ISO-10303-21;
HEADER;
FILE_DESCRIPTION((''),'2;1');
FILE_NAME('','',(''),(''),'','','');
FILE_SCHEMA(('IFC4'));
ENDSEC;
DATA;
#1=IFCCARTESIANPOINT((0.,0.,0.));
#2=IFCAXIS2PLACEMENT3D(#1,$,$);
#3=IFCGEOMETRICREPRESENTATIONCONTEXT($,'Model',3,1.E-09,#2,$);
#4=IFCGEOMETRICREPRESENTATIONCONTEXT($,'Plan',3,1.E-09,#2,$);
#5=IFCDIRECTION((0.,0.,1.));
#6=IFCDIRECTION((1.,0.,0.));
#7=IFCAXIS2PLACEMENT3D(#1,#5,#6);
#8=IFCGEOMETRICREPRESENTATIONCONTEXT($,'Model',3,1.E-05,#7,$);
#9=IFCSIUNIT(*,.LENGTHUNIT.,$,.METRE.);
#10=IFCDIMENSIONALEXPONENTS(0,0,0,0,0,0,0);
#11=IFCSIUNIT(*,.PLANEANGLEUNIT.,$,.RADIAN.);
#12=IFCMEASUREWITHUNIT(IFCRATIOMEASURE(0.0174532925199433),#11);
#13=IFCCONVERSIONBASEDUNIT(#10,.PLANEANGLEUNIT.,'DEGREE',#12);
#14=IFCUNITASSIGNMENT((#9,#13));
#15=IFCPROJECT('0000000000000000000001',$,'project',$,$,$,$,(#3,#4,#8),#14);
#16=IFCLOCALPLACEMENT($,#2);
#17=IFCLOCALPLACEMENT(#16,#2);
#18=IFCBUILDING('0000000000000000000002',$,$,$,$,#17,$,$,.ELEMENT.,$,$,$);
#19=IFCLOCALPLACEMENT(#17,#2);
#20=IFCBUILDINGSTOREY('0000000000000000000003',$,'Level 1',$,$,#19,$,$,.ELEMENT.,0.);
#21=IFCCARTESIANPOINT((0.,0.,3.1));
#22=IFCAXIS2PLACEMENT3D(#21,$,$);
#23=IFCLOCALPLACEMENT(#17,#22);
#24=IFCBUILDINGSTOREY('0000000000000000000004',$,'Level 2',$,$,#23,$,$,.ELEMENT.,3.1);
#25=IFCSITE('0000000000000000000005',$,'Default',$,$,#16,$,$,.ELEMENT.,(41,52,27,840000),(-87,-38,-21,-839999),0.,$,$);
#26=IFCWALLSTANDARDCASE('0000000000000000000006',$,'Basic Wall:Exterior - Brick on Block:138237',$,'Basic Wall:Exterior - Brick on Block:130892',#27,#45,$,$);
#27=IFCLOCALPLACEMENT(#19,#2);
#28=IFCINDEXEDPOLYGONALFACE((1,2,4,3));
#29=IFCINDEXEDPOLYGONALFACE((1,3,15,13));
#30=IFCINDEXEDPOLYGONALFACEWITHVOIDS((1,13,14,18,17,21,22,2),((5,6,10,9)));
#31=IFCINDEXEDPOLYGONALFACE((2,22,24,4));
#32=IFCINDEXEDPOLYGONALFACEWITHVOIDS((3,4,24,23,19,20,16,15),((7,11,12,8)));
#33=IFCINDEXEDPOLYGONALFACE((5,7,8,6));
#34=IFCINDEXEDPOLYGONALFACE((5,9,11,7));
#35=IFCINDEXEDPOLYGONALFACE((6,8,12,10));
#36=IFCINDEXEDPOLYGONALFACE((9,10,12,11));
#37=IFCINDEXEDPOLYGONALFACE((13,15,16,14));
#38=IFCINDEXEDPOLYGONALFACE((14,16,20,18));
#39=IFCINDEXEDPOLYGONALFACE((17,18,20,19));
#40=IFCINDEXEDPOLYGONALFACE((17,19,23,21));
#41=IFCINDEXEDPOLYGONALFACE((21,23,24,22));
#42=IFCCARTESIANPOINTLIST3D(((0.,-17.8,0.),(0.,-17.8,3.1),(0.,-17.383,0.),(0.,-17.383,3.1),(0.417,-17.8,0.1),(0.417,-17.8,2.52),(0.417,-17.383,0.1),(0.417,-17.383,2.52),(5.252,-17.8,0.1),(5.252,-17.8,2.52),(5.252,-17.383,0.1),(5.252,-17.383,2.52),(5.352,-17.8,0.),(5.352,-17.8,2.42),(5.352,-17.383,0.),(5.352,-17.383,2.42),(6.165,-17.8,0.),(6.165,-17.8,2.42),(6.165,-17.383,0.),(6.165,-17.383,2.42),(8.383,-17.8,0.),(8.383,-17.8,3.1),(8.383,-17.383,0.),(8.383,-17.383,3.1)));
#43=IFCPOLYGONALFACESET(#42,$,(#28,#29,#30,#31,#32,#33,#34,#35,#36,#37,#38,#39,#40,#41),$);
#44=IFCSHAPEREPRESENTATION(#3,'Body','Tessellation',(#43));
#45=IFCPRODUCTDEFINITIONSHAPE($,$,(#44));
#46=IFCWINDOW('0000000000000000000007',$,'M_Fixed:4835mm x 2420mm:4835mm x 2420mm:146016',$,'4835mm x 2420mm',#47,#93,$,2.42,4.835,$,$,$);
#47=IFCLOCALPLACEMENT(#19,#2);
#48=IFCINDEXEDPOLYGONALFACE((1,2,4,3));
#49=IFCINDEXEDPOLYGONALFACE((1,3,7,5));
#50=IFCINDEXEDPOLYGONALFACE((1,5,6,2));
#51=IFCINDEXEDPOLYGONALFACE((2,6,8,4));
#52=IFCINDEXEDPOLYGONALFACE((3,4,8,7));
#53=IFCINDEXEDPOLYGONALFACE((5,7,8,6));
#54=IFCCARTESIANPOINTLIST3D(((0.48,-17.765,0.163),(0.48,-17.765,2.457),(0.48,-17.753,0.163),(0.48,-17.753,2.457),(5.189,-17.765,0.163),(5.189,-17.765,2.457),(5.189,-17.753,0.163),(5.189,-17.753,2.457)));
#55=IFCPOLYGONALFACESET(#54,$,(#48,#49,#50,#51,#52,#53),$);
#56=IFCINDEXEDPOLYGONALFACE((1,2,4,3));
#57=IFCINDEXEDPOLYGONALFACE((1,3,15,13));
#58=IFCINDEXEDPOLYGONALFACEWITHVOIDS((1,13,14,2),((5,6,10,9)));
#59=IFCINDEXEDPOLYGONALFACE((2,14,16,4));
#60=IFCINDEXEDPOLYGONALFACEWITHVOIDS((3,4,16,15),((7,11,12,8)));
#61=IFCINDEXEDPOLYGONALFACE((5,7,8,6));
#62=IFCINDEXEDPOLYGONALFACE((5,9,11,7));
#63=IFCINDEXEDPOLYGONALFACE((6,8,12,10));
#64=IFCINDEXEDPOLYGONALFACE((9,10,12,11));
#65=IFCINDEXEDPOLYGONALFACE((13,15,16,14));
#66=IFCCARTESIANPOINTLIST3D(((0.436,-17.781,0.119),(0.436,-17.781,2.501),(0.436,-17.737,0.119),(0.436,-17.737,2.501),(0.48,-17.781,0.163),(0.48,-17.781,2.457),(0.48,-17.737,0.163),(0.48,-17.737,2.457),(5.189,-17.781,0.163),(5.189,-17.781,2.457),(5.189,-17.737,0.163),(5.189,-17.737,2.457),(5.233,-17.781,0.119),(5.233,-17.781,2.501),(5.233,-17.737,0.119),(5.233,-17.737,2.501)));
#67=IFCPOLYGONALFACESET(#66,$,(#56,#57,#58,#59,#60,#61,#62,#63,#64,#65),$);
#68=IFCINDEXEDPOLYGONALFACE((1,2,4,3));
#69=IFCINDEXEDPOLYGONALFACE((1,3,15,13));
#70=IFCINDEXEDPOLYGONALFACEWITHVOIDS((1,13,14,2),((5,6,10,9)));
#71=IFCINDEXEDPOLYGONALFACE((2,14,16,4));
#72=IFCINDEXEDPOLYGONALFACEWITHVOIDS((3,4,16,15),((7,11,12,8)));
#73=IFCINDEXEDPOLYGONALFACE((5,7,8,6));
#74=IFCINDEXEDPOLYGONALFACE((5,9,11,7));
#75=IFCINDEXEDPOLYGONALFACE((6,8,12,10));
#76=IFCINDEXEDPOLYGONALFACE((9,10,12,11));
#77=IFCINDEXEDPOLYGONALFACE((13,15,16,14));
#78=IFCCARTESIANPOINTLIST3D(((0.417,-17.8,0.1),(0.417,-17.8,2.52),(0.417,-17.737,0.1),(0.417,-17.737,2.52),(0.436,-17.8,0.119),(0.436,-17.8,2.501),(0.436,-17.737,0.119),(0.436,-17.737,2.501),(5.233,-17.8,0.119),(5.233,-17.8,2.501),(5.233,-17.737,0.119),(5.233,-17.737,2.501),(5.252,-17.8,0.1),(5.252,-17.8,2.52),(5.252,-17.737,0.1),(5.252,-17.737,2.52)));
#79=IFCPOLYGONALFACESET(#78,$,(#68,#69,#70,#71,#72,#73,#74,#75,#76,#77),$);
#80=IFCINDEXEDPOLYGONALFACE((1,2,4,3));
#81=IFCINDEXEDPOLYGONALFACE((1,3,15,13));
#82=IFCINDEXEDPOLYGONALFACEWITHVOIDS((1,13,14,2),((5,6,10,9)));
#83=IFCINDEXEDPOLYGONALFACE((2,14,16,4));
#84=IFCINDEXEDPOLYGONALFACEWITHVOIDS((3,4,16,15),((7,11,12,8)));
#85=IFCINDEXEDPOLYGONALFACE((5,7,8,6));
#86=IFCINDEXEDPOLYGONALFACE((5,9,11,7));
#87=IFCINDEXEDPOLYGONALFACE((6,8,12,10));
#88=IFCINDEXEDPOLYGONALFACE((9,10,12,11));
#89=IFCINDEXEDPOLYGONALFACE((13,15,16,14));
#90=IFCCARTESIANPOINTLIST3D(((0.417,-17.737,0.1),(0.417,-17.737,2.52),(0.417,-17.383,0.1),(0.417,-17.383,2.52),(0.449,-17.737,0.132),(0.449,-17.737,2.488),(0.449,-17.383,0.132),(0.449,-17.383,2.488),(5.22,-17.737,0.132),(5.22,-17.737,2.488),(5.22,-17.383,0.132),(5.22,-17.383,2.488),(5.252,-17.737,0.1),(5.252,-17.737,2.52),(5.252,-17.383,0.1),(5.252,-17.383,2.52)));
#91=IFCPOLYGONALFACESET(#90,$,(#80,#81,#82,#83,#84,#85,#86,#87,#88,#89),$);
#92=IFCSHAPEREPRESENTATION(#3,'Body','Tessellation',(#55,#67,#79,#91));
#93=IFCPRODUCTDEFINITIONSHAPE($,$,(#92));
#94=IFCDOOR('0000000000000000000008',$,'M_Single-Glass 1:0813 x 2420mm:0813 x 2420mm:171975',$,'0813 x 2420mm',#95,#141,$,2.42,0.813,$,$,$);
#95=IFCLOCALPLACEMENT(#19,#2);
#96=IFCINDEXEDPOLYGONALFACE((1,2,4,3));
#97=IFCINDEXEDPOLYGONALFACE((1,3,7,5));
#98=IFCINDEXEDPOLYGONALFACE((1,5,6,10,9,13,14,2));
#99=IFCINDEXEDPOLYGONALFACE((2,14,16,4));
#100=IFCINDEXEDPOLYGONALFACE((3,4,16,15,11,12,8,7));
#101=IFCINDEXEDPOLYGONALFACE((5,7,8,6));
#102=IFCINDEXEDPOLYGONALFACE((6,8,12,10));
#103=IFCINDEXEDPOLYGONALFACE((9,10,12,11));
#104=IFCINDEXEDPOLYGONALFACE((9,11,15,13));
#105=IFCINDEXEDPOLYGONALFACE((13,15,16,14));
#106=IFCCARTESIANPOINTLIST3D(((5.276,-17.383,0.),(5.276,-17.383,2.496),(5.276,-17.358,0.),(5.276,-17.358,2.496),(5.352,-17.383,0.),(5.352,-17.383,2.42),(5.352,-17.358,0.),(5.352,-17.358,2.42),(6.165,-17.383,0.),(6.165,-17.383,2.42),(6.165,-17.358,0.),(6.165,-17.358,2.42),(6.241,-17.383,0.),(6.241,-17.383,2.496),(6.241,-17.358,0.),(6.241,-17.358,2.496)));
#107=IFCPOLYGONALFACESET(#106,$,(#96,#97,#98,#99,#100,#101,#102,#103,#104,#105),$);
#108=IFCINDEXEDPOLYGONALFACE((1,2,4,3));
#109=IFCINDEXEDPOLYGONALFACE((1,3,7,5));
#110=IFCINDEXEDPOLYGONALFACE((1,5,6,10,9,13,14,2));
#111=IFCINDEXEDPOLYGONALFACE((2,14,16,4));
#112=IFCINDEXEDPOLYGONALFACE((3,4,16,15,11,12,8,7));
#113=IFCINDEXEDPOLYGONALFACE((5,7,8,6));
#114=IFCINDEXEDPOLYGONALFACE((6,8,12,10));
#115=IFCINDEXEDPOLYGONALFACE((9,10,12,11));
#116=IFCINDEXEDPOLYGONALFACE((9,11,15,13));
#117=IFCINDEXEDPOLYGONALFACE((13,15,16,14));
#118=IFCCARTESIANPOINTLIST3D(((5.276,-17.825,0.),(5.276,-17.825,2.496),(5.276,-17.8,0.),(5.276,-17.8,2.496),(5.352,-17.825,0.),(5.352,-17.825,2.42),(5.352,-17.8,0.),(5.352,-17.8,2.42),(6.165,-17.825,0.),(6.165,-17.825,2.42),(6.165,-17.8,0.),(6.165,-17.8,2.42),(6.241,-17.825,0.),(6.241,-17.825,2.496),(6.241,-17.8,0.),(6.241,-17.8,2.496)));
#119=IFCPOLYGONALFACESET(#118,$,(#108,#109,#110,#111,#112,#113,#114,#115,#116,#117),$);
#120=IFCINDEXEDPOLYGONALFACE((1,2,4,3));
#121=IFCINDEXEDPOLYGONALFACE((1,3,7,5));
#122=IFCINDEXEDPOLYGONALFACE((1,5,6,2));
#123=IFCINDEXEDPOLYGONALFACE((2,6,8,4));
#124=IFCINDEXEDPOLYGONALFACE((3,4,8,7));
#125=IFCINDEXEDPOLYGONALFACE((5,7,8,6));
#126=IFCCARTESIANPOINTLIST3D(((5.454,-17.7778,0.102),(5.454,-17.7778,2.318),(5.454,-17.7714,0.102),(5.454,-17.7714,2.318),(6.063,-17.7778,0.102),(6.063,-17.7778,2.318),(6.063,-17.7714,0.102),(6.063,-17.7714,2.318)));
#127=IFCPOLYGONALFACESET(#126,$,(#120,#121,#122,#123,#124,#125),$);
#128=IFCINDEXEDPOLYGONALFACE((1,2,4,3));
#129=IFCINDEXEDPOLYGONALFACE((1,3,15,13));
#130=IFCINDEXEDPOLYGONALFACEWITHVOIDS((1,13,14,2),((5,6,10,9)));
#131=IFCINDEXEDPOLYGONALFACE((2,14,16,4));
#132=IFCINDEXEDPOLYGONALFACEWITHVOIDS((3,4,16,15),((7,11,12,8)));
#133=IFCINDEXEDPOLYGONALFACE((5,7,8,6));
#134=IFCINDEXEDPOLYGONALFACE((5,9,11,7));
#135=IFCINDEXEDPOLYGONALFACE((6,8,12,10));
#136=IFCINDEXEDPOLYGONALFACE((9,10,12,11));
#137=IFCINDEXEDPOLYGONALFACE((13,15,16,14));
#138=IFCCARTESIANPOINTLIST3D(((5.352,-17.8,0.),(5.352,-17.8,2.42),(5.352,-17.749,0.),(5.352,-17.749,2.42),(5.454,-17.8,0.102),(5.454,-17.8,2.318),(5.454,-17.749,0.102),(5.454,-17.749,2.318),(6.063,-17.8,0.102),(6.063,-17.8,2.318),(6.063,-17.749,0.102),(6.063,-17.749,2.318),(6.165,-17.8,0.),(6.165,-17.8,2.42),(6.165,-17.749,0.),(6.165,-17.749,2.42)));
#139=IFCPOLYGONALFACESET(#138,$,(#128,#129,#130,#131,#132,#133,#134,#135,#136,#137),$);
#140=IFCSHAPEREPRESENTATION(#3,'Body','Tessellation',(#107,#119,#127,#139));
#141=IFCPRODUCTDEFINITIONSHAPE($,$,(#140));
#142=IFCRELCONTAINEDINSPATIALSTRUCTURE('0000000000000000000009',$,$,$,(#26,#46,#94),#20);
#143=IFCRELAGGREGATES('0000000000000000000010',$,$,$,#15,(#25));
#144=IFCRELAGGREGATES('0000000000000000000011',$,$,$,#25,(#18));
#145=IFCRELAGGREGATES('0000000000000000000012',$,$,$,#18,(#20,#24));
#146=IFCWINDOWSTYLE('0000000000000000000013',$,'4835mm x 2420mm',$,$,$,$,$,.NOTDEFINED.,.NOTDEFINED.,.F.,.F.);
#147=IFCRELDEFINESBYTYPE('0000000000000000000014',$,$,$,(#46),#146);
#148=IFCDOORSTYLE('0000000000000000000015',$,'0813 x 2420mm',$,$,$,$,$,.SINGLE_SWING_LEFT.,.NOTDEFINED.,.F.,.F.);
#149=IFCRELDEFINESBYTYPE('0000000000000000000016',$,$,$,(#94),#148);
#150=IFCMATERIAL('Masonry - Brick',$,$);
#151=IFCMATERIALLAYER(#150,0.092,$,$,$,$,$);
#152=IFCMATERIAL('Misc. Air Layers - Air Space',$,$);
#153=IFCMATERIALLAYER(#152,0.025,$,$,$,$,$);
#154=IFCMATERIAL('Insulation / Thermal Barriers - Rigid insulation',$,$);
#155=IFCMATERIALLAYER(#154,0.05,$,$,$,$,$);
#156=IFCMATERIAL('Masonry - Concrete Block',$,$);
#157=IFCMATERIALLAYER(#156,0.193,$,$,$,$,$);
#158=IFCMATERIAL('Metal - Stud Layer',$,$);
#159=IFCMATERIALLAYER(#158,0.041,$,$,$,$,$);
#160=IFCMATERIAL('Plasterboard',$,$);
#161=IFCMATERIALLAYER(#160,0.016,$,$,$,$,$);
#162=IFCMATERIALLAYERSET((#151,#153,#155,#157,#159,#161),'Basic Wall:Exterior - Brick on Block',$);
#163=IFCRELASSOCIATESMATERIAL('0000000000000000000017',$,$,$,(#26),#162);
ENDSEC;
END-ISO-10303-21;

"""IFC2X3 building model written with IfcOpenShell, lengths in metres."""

from ifc_helpers import new_model, entity, si_unit, converted_unit, frame, frame_2d, origin, origin_with_axes, origin_2d_with_axis, place, context, project, spatial, polyline, rectangle, outline, extrude, source, transform, mapped, material, layer, layer_set, layer_usage, type_object, type_shapes, element, fill, save


model = new_model("IFC2X3")

# Units and contexts
model_context_1 = context("Model", 3, precision=1e-09, world=origin())
plan_context = context("Plan", 3, precision=1e-09, world=origin())
model_context_2 = context("Model", 3, precision=1e-05, world=origin_with_axes())
ifc_project = project(units=[si_unit("LENGTHUNIT", "METRE"), converted_unit("PLANEANGLEUNIT", "DEGREE", entity("IfcRatioMeasure", 0.0174532925199433), si_unit("PLANEANGLEUNIT", "RADIAN"), dimensions=[0, 0, 0, 0, 0, 0, 0])], contexts=[model_context_1, plan_context, model_context_2])

# Site, building, storey
site_placement = place(None, origin())
site = spatial("IfcSite", under=ifc_project, at=site_placement, Name="Default", CompositionType="ELEMENT", RefLatitude=(41, 52, 27, 840000), RefLongitude=(-87, -38, -21, -839999), RefElevation=0.0)
building_placement = place(site_placement, origin())
building = spatial("IfcBuilding", under=site, at=building_placement, CompositionType="ELEMENT")
storey_1_placement = place(building_placement, origin())
storey_1 = spatial("IfcBuildingStorey", under=building, at=storey_1_placement, Name="Level 1", CompositionType="ELEMENT", Elevation=0.0)

# Wall, openings, window, door
ifc_material_1 = material(Name="Masonry - Brick")
ifc_layer_1 = layer(ifc_material_1, 0.092)
ifc_material_2 = material(Name="Misc. Air Layers - Air Space")
ifc_layer_2 = layer(ifc_material_2, 0.025)
ifc_material_3 = material(Name="Insulation / Thermal Barriers - Rigid insulation")
ifc_layer_3 = layer(ifc_material_3, 0.05)
ifc_material_4 = material(Name="Masonry - Concrete Block")
ifc_layer_4 = layer(ifc_material_4, 0.193)
ifc_material_5 = material(Name="Metal - Stud Layer")
ifc_layer_5 = layer(ifc_material_5, 0.041)
ifc_material_6 = material(Name="Plasterboard")
ifc_layer_6 = layer(ifc_material_6, 0.016)
ifc_layer_set_1 = layer_set([ifc_layer_1, ifc_layer_2, ifc_layer_3, ifc_layer_4, ifc_layer_5, ifc_layer_6], Name="Basic Wall:Exterior - Brick on Block")
ifc_layer_usage_1 = layer_usage(ifc_layer_set_1, "AXIS2", "NEGATIVE", 0.2085)
wall_1_placement = place(storey_1_placement, frame((8.383, -17.5915, 0.0), z_axis=(0.0, 0.0, 1.0), x_axis=(-1.0, 0.0, 0.0)))
wall_1 = element("IfcWallStandardCase", 1, at=wall_1_placement, inside=storey_1, material=ifc_layer_usage_1, Name="Basic Wall:Exterior - Brick on Block:138237", ObjectType="Basic Wall:Exterior - Brick on Block:130892", context=model_context_1, shape_type="SweptSolid", body=[
    extrude(rectangle(XDim=8.383, YDim=0.417, at=frame_2d((4.1915, 0.0), x_axis=(-1.0, 0.0))), origin(), (0.0, 0.0, 1.0), 3.1),
])
opening_1_placement = place(wall_1_placement, frame((3.131, -0.2085, 0.1)))
opening_1 = element("IfcOpeningElement", 2, at=opening_1_placement, cuts=wall_1, ObjectType="Opening", context=model_context_1, shape_type="SweptSolid", body=[
    extrude(rectangle(XDim=2.42, YDim=4.835, at=frame_2d((1.21, 2.4175), x_axis=(1.0, 0.0))), frame((0.0, 0.0, 0.0), z_axis=(0.0, 1.0, 0.0), x_axis=(0.0, 0.0, 1.0)), (0.0, 0.0, 1.0), 0.417),
])
opening_2_placement = place(wall_1_placement, frame((2.218, -0.2085, 0.0)))
opening_2 = element("IfcOpeningElement", 3, at=opening_2_placement, cuts=wall_1, ObjectType="Opening", context=model_context_1, shape_type="SweptSolid", body=[
    extrude(rectangle(XDim=0.813, YDim=2.42, at=frame_2d((1.21, 0.4065), x_axis=(0.0, -1.0))), frame((0.0, 0.0, 0.0), z_axis=(0.0, 1.0, 0.0), x_axis=(0.0, 0.0, 1.0)), (0.0, 0.0, 1.0), 0.417),
])
window_style_1 = type_object("IfcWindowStyle", Name="4835mm x 2420mm", ConstructionType="NOTDEFINED", OperationType="NOTDEFINED", ParameterTakesPrecedence=False, Sizeable=False)
shared_shape_1 = source(origin(), model_context_1, "Body", "SweptSolid", [
    extrude(rectangle(XDim=0.012, YDim=4.709, at=origin_2d_with_axis()), frame((2.4175, 0.376, 0.063), z_axis=(0.0, 0.0, 1.0), x_axis=(0.0, -1.0, 0.0)), (0.0, 0.0, 1.0), 2.294),
    extrude(outline(polyline([(-2.3985, -1.191), (2.3985, -1.191), (2.3985, 1.191), (-2.3985, 1.191), (-2.3985, -1.191)]), holes=[polyline([(-2.3545, -1.147), (-2.3545, 1.147), (2.3545, 1.147), (2.3545, -1.147), (-2.3545, -1.147)])]), frame((2.4175, 0.354, 1.21), z_axis=(0.0, 1.0, 0.0), x_axis=(1.0, 0.0, 0.0)), (0.0, 0.0, 1.0), 0.044),
    extrude(outline(polyline([(-2.4175, -1.21), (2.4175, -1.21), (2.4175, 1.21), (-2.4175, 1.21), (-2.4175, -1.21)]), holes=[polyline([(-2.3985, -1.191), (-2.3985, 1.191), (2.3985, 1.191), (2.3985, -1.191), (-2.3985, -1.191)])]), frame((2.4175, 0.354, 1.21), z_axis=(0.0, 1.0, 0.0), x_axis=(1.0, 0.0, 0.0)), (0.0, 0.0, 1.0), 0.063),
    extrude(outline(polyline([(-2.4175, -1.21), (2.4175, -1.21), (2.4175, 1.21), (-2.4175, 1.21), (-2.4175, -1.21)]), holes=[polyline([(-2.3855, -1.178), (-2.3855, 1.178), (2.3855, 1.178), (2.3855, -1.178), (-2.3855, -1.178)])]), frame((2.4175, 0.0, 1.21), z_axis=(0.0, 1.0, 0.0), x_axis=(1.0, 0.0, 0.0)), (0.0, 0.0, 1.0), 0.354),
])
type_shapes(window_style_1, [shared_shape_1])
window_1_placement = place(opening_1_placement, origin())
window_1 = element("IfcWindow", 4, at=window_1_placement, inside=storey_1, type_object=window_style_1, Name="M_Fixed:4835mm x 2420mm:4835mm x 2420mm:146016", ObjectType="4835mm x 2420mm", OverallHeight=2.42, OverallWidth=4.835, context=model_context_1, shape_type="MappedRepresentation", body=[
    mapped(shared_shape_1, transform((0.0, 0.0, 0.0), scale=1.0)),
])
fill(opening_1, window_1)
door_style_1 = type_object("IfcDoorStyle", Name="0813 x 2420mm", ConstructionType="NOTDEFINED", OperationType="SINGLE_SWING_LEFT", ParameterTakesPrecedence=False, Sizeable=False)
shared_shape_2 = source(origin(), model_context_1, "Body", "SweptSolid", [
    extrude(outline(polyline([(-0.4065, -1.191), (-0.4065, 1.229), (-0.4825, 1.229), (-0.4825, -1.267), (0.4825, -1.267), (0.4825, 1.229), (0.4065, 1.229), (0.4065, -1.191), (-0.4065, -1.191)])), frame((0.4065, 0.0, 1.229), z_axis=(0.0, 1.0, 0.0), x_axis=(1.0, 0.0, 0.0)), (0.0, 0.0, -1.0), 0.025),
    extrude(outline(polyline([(-0.4065, -1.191), (-0.4065, 1.229), (-0.4825, 1.229), (-0.4825, -1.267), (0.4825, -1.267), (0.4825, 1.229), (0.4065, 1.229), (0.4065, -1.191), (-0.4065, -1.191)])), frame((0.4065, 0.442, 1.229), z_axis=(0.0, 1.0, 0.0), x_axis=(1.0, 0.0, 0.0)), (0.0, 0.0, -1.0), 0.025),
    extrude(rectangle(XDim=0.609, YDim=0.0064, at=origin_2d_with_axis()), frame((0.4065, 0.3916, 0.102)), (0.0, 0.0, 1.0), 2.216),
    extrude(outline(polyline([(-1.21, -0.4065), (1.21, -0.4065), (1.21, 0.4065), (-1.21, 0.4065), (-1.21, -0.4065)]), holes=[polyline([(-1.108, 0.3045), (1.108, 0.3045), (1.108, -0.3045), (-1.108, -0.3045), (-1.108, 0.3045)])]), frame((0.4065, 0.417, 1.21), z_axis=(0.0, -1.0, 0.0), x_axis=(0.0, 0.0, -1.0)), (0.0, 0.0, 1.0), 0.051),
])
type_shapes(door_style_1, [shared_shape_2])
door_1_placement = place(opening_2_placement, origin())
door_1 = element("IfcDoor", 5, at=door_1_placement, inside=storey_1, type_object=door_style_1, Name="M_Single-Glass 1:0813 x 2420mm:0813 x 2420mm:171975", ObjectType="0813 x 2420mm", OverallHeight=2.42, OverallWidth=0.813, context=model_context_1, shape_type="MappedRepresentation", body=[
    mapped(shared_shape_2, transform((0.0, 0.0, 0.0), scale=1.0)),
])
fill(opening_2, door_1)

# Shared definitions
storey_2_placement = place(building_placement, frame((0.0, 0.0, 3.1)))
storey_2 = spatial("IfcBuildingStorey", under=building, at=storey_2_placement, Name="Level 2", CompositionType="ELEMENT", Elevation=3.1)

save(model, "model.ifc")
